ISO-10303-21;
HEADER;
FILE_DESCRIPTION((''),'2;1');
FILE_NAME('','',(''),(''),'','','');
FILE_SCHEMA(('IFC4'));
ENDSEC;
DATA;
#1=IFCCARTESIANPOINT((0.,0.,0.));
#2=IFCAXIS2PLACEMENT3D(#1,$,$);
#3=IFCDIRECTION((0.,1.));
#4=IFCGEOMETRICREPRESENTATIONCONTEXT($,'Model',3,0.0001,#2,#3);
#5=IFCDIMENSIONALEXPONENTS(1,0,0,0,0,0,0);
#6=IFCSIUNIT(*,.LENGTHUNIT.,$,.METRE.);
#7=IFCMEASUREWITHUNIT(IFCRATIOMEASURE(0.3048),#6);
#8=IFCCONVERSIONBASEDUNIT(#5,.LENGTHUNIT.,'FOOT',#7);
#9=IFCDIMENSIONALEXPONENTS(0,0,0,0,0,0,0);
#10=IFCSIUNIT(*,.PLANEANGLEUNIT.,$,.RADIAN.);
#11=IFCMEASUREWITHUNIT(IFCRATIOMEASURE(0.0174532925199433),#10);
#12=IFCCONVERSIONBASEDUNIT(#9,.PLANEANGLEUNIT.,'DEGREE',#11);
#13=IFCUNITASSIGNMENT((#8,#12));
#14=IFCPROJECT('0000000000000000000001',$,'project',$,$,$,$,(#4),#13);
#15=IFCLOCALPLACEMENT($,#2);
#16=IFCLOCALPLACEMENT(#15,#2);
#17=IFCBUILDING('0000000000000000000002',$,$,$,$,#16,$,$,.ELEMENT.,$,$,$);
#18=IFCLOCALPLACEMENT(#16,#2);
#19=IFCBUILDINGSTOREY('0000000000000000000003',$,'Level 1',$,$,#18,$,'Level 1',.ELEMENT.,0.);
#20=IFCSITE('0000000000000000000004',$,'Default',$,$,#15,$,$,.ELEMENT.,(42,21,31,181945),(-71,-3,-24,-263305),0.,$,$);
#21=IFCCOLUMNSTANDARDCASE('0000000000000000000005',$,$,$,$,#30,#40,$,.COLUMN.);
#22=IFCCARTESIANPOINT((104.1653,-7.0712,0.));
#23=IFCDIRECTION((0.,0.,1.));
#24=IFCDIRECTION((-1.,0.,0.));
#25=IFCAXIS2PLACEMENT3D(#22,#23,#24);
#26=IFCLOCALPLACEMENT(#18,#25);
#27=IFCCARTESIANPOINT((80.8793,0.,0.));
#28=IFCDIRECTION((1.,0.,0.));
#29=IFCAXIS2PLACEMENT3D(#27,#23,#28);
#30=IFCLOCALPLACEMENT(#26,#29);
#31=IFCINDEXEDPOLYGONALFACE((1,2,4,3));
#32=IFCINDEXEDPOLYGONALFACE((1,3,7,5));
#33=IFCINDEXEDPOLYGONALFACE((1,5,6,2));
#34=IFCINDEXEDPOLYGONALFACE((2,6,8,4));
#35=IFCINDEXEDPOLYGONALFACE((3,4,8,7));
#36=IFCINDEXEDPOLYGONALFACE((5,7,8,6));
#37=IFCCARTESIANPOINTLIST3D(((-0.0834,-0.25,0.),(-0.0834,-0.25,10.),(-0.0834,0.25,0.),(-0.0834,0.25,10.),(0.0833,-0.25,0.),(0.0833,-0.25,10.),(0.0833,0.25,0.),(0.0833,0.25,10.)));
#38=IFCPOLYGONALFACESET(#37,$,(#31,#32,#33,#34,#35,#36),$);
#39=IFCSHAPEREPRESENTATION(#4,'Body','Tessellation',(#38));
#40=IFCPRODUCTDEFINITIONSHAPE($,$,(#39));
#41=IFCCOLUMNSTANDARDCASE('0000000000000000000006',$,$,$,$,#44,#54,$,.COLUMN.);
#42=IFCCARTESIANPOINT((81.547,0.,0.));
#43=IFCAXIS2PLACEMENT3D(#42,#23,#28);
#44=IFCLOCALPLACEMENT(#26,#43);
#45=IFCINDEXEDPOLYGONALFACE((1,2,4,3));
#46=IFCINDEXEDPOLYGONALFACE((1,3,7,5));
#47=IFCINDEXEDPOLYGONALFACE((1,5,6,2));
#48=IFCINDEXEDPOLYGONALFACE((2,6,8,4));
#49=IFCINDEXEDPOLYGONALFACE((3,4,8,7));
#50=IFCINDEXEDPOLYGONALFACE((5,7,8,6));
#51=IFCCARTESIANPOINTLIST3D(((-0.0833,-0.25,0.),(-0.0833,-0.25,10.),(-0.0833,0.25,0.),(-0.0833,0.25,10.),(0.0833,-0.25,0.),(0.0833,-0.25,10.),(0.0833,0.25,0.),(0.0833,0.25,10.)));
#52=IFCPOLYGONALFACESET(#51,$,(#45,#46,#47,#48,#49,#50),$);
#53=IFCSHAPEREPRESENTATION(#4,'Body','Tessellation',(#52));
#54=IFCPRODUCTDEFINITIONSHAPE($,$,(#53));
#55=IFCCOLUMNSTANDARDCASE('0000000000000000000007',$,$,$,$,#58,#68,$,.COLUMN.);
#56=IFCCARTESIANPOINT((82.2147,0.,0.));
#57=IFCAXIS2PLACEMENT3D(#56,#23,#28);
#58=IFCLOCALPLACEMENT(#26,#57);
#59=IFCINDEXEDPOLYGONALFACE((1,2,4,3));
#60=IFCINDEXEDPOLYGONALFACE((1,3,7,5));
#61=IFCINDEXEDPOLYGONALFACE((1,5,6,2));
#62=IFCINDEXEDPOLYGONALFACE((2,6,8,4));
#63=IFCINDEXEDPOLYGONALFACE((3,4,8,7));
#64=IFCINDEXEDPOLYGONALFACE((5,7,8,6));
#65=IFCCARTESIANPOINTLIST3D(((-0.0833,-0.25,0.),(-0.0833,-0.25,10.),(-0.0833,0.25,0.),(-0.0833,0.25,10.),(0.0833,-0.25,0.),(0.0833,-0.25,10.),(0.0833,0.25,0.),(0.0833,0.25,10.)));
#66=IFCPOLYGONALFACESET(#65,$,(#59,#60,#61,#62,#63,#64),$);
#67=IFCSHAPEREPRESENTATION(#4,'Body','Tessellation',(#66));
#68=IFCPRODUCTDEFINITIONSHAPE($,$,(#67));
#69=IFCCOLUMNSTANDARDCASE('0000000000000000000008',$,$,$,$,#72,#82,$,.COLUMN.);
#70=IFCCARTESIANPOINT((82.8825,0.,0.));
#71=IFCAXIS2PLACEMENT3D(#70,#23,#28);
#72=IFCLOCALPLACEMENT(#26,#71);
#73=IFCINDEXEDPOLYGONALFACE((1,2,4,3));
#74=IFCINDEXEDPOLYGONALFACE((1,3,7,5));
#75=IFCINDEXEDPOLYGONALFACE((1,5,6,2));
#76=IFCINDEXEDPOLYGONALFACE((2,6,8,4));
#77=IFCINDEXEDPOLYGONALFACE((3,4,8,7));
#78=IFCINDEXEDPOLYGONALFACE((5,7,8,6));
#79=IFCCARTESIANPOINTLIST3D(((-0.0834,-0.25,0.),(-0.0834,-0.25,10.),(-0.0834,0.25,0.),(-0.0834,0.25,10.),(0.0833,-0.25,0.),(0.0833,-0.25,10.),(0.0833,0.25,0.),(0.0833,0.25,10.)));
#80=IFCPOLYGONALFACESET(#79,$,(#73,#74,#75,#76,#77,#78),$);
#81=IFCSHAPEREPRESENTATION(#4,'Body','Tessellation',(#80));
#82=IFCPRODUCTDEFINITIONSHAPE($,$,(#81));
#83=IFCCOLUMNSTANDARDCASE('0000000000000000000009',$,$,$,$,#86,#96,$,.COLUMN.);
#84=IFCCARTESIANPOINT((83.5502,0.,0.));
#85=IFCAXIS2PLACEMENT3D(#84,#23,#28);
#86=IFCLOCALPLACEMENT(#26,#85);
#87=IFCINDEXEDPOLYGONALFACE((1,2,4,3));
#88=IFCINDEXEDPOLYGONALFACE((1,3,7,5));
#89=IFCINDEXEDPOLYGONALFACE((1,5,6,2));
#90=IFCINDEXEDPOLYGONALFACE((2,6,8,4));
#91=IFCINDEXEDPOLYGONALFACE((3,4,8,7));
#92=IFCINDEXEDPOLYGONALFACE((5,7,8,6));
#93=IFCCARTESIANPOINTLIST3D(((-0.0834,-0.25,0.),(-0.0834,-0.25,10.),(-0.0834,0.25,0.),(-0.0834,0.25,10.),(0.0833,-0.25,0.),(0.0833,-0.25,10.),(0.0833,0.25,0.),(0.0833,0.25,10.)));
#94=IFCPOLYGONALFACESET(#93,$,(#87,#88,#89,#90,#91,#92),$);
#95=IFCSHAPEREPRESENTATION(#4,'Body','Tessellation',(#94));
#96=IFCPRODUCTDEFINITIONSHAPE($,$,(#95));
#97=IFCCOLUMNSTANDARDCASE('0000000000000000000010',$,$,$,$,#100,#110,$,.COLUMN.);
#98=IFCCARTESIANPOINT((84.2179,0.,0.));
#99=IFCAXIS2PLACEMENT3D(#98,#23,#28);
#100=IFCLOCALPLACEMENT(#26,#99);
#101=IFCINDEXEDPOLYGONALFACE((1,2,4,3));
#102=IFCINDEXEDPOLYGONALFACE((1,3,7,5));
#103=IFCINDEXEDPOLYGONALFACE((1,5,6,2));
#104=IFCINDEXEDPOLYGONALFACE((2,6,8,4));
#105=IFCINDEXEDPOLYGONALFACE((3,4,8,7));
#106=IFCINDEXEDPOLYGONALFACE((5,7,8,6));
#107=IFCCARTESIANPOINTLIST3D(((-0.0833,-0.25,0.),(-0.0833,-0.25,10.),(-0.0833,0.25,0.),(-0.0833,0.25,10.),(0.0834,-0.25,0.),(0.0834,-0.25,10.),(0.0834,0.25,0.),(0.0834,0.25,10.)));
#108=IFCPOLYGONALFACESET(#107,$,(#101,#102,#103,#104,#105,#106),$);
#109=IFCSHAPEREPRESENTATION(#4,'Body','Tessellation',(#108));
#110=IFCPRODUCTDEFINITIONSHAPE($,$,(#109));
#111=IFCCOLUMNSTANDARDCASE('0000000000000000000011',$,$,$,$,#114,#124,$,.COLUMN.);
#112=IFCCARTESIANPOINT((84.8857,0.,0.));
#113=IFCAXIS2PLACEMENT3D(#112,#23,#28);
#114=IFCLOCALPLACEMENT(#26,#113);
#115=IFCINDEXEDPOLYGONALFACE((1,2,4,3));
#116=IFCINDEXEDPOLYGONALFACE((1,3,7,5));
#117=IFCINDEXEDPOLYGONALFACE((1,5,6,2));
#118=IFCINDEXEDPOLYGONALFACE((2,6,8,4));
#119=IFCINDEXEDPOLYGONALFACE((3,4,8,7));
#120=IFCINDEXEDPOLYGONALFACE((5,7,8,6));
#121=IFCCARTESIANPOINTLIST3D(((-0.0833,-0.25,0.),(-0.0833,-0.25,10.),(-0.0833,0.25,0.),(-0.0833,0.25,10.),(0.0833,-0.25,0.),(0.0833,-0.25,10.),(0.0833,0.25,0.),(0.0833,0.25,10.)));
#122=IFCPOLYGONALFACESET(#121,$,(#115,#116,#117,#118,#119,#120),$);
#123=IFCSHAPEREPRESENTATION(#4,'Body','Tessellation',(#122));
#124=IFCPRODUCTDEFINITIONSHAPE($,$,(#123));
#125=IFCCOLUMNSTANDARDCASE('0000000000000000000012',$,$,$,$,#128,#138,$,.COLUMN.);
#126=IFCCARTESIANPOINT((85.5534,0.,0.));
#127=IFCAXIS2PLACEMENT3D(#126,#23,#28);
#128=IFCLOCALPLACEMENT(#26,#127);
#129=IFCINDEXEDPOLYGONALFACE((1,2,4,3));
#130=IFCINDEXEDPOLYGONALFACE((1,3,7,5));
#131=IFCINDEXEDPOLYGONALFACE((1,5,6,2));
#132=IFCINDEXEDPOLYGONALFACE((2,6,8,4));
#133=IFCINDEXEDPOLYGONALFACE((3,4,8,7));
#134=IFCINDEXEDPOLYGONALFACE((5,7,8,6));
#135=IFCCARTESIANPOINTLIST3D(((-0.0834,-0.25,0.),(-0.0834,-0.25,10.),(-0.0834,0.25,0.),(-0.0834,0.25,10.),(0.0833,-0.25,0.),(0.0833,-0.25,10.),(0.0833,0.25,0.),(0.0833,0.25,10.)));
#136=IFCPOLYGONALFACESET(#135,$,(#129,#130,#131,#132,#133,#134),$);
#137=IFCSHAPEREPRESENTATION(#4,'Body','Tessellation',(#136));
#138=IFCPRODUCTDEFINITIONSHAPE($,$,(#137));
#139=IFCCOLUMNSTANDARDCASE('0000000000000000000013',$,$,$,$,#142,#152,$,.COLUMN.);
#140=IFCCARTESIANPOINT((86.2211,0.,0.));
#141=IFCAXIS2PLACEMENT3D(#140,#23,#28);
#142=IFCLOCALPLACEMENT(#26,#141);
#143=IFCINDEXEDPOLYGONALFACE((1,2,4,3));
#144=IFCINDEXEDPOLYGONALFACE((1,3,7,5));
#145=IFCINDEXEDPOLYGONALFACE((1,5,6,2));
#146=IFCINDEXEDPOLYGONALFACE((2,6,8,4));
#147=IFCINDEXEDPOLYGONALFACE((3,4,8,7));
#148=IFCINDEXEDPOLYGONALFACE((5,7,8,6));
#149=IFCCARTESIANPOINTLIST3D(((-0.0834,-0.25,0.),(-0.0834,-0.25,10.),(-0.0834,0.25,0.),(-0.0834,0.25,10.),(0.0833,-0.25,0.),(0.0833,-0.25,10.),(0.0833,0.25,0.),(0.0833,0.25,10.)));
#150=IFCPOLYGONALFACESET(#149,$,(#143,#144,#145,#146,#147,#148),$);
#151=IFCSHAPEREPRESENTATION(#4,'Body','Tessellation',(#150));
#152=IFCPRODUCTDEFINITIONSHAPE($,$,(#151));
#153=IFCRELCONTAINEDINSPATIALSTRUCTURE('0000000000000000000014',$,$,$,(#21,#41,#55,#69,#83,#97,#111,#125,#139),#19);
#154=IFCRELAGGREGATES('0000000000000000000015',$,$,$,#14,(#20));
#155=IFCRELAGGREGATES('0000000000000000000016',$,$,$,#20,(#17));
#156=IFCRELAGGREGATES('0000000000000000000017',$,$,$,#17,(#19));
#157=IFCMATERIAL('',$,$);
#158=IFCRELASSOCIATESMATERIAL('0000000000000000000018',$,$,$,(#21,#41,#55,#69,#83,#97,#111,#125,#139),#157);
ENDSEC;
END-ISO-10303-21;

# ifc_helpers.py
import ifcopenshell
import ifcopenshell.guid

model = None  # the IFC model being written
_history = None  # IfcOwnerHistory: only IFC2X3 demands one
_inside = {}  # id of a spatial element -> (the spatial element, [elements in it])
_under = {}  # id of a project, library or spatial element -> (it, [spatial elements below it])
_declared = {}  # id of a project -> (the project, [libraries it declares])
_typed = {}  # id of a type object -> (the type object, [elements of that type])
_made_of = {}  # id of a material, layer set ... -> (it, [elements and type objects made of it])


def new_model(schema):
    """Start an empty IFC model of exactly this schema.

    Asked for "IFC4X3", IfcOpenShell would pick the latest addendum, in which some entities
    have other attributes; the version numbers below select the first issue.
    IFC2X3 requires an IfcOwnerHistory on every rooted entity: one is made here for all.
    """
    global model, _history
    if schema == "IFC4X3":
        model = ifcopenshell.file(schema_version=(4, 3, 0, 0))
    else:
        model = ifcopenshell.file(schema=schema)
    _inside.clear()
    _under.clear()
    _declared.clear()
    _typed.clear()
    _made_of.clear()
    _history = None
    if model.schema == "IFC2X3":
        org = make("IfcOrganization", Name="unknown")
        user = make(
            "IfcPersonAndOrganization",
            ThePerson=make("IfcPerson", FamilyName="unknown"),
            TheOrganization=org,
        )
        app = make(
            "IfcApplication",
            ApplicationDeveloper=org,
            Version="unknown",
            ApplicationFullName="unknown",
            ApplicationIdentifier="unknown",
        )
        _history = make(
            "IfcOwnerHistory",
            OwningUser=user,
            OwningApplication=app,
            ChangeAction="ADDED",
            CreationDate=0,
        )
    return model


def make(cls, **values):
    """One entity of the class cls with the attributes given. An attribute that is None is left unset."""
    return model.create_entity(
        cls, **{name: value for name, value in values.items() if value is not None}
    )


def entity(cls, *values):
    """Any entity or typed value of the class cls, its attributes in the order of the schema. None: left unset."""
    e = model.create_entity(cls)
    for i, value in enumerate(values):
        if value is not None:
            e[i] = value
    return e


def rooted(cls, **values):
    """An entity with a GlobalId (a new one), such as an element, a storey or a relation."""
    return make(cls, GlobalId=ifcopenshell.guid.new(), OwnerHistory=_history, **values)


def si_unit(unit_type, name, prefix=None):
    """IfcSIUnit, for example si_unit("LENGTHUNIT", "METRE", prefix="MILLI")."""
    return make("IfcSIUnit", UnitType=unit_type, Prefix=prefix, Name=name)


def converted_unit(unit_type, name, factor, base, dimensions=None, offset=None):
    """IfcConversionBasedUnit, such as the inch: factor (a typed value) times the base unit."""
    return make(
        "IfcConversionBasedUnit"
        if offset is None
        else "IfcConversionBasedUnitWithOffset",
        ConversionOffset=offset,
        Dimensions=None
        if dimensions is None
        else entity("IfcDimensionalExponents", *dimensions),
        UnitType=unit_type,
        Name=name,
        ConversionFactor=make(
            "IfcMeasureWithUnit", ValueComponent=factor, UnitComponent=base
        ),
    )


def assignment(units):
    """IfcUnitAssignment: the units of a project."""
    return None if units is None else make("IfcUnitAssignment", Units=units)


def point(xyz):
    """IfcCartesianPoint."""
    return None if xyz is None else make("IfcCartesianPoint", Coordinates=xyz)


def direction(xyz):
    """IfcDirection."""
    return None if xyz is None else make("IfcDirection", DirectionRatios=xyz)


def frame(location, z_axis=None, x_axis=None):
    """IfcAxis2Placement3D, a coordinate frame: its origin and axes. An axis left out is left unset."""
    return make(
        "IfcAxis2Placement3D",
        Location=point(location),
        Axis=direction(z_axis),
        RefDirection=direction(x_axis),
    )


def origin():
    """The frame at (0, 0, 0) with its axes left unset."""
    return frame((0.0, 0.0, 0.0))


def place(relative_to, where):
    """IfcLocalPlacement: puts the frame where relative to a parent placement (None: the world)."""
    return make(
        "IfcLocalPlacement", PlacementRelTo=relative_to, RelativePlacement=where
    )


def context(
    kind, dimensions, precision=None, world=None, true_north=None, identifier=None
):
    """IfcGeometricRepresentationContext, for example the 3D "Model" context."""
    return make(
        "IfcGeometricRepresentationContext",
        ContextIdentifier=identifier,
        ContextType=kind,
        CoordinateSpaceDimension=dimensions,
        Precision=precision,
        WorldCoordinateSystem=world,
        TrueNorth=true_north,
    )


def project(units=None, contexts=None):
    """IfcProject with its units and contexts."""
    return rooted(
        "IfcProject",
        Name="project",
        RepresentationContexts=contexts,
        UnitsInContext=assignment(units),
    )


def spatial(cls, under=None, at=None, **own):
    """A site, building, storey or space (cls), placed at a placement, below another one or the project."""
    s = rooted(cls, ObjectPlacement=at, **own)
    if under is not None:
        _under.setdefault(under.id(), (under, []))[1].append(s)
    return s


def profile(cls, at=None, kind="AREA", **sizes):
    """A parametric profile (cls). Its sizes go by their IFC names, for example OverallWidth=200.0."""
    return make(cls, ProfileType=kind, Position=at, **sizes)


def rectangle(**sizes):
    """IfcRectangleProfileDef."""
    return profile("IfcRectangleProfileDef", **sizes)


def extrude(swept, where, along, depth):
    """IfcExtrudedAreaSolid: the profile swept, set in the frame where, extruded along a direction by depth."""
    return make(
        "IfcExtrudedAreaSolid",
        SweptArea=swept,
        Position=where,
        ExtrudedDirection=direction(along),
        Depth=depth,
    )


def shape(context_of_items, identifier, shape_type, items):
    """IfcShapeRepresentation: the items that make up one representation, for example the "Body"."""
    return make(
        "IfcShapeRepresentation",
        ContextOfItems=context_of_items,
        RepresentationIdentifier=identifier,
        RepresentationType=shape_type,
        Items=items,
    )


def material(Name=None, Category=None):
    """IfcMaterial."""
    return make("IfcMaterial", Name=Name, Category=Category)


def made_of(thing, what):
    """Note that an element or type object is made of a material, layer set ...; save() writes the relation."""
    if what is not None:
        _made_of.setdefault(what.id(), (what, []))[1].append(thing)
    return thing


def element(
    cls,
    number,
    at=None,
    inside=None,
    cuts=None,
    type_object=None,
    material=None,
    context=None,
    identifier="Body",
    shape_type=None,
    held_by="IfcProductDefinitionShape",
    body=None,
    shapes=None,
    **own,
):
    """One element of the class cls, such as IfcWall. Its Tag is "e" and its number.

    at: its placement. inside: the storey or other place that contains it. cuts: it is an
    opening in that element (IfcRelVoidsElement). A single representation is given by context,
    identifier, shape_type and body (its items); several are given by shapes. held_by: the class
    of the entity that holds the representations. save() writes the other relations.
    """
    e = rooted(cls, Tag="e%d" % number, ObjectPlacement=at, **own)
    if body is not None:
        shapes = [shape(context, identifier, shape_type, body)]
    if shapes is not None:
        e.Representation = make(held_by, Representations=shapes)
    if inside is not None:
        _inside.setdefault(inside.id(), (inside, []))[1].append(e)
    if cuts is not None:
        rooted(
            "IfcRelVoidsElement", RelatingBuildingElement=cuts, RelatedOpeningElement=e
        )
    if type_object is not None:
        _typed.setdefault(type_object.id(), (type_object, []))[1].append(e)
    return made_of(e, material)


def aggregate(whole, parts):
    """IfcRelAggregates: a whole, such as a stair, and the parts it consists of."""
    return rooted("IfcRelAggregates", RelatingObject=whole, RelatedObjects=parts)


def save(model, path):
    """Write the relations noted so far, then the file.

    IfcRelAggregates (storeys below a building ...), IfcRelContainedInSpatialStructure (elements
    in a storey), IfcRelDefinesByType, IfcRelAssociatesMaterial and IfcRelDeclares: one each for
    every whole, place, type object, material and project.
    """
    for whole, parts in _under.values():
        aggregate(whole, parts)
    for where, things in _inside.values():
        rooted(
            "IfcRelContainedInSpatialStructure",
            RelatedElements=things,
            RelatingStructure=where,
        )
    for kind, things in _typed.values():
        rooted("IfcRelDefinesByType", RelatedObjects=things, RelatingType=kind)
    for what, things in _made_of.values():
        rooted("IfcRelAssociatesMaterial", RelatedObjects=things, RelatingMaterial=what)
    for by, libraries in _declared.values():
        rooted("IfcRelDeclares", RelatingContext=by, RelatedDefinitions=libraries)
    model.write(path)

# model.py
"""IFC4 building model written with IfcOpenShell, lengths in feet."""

from ifc_helpers import new_model, entity, si_unit, converted_unit, direction, frame, origin, place, context, project, spatial, rectangle, extrude, material, element, save


model = new_model("IFC4")

# Units and contexts
model_context = context("Model", 3, precision=0.0001, world=origin(), true_north=direction((0.0, 1.0)))
ifc_project = project(units=[converted_unit("LENGTHUNIT", "FOOT", entity("IfcRatioMeasure", 0.3048), si_unit("LENGTHUNIT", "METRE"), dimensions=[1, 0, 0, 0, 0, 0, 0]), converted_unit("PLANEANGLEUNIT", "DEGREE", entity("IfcRatioMeasure", 0.0174532925199433), si_unit("PLANEANGLEUNIT", "RADIAN"), dimensions=[0, 0, 0, 0, 0, 0, 0])], contexts=[model_context])

# Site, building, storey
site_placement = place(None, origin())
site = spatial("IfcSite", under=ifc_project, at=site_placement, Name="Default", CompositionType="ELEMENT", RefLatitude=(42, 21, 31, 181945), RefLongitude=(-71, -3, -24, -263305), RefElevation=0.0)
building_placement = place(site_placement, origin())
building = spatial("IfcBuilding", under=site, at=building_placement, CompositionType="ELEMENT")
storey_placement = place(building_placement, origin())
storey = spatial("IfcBuildingStorey", under=building, at=storey_placement, Name="Level 1", LongName="Level 1", CompositionType="ELEMENT", Elevation=0.0)

# Columns
ifc_material_1 = material(Name="")
placement = place(storey_placement, frame((104.1653, -7.0712, 0.0), z_axis=(0.0, 0.0, 1.0), x_axis=(-1.0, 0.0, 0.0)))
for number, where, z_axis, x_axis in (
    (1, (80.8793, 0.0, 0.0), (0.0, 0.0, 1.0), (1.0, 0.0, 0.0)),
    (2, (81.547, 0.0, 0.0), (0.0, 0.0, 1.0), (1.0, 0.0, 0.0)),
    (3, (82.2147, 0.0, 0.0), (0.0, 0.0, 1.0), (1.0, 0.0, 0.0)),
    (4, (82.8825, 0.0, 0.0), (0.0, 0.0, 1.0), (1.0, 0.0, 0.0)),
    (5, (83.5502, 0.0, 0.0), (0.0, 0.0, 1.0), (1.0, 0.0, 0.0)),
    (6, (84.2179, 0.0, 0.0), (0.0, 0.0, 1.0), (1.0, 0.0, 0.0)),
    (7, (84.8857, 0.0, 0.0), (0.0, 0.0, 1.0), (1.0, 0.0, 0.0)),
    (8, (85.5534, 0.0, 0.0), (0.0, 0.0, 1.0), (1.0, 0.0, 0.0)),
    (9, (86.2211, 0.0, 0.0), (0.0, 0.0, 1.0), (1.0, 0.0, 0.0)),
):
    element("IfcColumnStandardCase", number, at=place(placement, frame(where, z_axis=z_axis, x_axis=x_axis)), inside=storey, material=ifc_material_1, PredefinedType="COLUMN", context=model_context, shape_type="SweptSolid", body=[
        extrude(rectangle(XDim=0.1667, YDim=0.5), origin(), (0.0, 0.0, 1.0), 10.0),
    ])

save(model, "model.ifc")
